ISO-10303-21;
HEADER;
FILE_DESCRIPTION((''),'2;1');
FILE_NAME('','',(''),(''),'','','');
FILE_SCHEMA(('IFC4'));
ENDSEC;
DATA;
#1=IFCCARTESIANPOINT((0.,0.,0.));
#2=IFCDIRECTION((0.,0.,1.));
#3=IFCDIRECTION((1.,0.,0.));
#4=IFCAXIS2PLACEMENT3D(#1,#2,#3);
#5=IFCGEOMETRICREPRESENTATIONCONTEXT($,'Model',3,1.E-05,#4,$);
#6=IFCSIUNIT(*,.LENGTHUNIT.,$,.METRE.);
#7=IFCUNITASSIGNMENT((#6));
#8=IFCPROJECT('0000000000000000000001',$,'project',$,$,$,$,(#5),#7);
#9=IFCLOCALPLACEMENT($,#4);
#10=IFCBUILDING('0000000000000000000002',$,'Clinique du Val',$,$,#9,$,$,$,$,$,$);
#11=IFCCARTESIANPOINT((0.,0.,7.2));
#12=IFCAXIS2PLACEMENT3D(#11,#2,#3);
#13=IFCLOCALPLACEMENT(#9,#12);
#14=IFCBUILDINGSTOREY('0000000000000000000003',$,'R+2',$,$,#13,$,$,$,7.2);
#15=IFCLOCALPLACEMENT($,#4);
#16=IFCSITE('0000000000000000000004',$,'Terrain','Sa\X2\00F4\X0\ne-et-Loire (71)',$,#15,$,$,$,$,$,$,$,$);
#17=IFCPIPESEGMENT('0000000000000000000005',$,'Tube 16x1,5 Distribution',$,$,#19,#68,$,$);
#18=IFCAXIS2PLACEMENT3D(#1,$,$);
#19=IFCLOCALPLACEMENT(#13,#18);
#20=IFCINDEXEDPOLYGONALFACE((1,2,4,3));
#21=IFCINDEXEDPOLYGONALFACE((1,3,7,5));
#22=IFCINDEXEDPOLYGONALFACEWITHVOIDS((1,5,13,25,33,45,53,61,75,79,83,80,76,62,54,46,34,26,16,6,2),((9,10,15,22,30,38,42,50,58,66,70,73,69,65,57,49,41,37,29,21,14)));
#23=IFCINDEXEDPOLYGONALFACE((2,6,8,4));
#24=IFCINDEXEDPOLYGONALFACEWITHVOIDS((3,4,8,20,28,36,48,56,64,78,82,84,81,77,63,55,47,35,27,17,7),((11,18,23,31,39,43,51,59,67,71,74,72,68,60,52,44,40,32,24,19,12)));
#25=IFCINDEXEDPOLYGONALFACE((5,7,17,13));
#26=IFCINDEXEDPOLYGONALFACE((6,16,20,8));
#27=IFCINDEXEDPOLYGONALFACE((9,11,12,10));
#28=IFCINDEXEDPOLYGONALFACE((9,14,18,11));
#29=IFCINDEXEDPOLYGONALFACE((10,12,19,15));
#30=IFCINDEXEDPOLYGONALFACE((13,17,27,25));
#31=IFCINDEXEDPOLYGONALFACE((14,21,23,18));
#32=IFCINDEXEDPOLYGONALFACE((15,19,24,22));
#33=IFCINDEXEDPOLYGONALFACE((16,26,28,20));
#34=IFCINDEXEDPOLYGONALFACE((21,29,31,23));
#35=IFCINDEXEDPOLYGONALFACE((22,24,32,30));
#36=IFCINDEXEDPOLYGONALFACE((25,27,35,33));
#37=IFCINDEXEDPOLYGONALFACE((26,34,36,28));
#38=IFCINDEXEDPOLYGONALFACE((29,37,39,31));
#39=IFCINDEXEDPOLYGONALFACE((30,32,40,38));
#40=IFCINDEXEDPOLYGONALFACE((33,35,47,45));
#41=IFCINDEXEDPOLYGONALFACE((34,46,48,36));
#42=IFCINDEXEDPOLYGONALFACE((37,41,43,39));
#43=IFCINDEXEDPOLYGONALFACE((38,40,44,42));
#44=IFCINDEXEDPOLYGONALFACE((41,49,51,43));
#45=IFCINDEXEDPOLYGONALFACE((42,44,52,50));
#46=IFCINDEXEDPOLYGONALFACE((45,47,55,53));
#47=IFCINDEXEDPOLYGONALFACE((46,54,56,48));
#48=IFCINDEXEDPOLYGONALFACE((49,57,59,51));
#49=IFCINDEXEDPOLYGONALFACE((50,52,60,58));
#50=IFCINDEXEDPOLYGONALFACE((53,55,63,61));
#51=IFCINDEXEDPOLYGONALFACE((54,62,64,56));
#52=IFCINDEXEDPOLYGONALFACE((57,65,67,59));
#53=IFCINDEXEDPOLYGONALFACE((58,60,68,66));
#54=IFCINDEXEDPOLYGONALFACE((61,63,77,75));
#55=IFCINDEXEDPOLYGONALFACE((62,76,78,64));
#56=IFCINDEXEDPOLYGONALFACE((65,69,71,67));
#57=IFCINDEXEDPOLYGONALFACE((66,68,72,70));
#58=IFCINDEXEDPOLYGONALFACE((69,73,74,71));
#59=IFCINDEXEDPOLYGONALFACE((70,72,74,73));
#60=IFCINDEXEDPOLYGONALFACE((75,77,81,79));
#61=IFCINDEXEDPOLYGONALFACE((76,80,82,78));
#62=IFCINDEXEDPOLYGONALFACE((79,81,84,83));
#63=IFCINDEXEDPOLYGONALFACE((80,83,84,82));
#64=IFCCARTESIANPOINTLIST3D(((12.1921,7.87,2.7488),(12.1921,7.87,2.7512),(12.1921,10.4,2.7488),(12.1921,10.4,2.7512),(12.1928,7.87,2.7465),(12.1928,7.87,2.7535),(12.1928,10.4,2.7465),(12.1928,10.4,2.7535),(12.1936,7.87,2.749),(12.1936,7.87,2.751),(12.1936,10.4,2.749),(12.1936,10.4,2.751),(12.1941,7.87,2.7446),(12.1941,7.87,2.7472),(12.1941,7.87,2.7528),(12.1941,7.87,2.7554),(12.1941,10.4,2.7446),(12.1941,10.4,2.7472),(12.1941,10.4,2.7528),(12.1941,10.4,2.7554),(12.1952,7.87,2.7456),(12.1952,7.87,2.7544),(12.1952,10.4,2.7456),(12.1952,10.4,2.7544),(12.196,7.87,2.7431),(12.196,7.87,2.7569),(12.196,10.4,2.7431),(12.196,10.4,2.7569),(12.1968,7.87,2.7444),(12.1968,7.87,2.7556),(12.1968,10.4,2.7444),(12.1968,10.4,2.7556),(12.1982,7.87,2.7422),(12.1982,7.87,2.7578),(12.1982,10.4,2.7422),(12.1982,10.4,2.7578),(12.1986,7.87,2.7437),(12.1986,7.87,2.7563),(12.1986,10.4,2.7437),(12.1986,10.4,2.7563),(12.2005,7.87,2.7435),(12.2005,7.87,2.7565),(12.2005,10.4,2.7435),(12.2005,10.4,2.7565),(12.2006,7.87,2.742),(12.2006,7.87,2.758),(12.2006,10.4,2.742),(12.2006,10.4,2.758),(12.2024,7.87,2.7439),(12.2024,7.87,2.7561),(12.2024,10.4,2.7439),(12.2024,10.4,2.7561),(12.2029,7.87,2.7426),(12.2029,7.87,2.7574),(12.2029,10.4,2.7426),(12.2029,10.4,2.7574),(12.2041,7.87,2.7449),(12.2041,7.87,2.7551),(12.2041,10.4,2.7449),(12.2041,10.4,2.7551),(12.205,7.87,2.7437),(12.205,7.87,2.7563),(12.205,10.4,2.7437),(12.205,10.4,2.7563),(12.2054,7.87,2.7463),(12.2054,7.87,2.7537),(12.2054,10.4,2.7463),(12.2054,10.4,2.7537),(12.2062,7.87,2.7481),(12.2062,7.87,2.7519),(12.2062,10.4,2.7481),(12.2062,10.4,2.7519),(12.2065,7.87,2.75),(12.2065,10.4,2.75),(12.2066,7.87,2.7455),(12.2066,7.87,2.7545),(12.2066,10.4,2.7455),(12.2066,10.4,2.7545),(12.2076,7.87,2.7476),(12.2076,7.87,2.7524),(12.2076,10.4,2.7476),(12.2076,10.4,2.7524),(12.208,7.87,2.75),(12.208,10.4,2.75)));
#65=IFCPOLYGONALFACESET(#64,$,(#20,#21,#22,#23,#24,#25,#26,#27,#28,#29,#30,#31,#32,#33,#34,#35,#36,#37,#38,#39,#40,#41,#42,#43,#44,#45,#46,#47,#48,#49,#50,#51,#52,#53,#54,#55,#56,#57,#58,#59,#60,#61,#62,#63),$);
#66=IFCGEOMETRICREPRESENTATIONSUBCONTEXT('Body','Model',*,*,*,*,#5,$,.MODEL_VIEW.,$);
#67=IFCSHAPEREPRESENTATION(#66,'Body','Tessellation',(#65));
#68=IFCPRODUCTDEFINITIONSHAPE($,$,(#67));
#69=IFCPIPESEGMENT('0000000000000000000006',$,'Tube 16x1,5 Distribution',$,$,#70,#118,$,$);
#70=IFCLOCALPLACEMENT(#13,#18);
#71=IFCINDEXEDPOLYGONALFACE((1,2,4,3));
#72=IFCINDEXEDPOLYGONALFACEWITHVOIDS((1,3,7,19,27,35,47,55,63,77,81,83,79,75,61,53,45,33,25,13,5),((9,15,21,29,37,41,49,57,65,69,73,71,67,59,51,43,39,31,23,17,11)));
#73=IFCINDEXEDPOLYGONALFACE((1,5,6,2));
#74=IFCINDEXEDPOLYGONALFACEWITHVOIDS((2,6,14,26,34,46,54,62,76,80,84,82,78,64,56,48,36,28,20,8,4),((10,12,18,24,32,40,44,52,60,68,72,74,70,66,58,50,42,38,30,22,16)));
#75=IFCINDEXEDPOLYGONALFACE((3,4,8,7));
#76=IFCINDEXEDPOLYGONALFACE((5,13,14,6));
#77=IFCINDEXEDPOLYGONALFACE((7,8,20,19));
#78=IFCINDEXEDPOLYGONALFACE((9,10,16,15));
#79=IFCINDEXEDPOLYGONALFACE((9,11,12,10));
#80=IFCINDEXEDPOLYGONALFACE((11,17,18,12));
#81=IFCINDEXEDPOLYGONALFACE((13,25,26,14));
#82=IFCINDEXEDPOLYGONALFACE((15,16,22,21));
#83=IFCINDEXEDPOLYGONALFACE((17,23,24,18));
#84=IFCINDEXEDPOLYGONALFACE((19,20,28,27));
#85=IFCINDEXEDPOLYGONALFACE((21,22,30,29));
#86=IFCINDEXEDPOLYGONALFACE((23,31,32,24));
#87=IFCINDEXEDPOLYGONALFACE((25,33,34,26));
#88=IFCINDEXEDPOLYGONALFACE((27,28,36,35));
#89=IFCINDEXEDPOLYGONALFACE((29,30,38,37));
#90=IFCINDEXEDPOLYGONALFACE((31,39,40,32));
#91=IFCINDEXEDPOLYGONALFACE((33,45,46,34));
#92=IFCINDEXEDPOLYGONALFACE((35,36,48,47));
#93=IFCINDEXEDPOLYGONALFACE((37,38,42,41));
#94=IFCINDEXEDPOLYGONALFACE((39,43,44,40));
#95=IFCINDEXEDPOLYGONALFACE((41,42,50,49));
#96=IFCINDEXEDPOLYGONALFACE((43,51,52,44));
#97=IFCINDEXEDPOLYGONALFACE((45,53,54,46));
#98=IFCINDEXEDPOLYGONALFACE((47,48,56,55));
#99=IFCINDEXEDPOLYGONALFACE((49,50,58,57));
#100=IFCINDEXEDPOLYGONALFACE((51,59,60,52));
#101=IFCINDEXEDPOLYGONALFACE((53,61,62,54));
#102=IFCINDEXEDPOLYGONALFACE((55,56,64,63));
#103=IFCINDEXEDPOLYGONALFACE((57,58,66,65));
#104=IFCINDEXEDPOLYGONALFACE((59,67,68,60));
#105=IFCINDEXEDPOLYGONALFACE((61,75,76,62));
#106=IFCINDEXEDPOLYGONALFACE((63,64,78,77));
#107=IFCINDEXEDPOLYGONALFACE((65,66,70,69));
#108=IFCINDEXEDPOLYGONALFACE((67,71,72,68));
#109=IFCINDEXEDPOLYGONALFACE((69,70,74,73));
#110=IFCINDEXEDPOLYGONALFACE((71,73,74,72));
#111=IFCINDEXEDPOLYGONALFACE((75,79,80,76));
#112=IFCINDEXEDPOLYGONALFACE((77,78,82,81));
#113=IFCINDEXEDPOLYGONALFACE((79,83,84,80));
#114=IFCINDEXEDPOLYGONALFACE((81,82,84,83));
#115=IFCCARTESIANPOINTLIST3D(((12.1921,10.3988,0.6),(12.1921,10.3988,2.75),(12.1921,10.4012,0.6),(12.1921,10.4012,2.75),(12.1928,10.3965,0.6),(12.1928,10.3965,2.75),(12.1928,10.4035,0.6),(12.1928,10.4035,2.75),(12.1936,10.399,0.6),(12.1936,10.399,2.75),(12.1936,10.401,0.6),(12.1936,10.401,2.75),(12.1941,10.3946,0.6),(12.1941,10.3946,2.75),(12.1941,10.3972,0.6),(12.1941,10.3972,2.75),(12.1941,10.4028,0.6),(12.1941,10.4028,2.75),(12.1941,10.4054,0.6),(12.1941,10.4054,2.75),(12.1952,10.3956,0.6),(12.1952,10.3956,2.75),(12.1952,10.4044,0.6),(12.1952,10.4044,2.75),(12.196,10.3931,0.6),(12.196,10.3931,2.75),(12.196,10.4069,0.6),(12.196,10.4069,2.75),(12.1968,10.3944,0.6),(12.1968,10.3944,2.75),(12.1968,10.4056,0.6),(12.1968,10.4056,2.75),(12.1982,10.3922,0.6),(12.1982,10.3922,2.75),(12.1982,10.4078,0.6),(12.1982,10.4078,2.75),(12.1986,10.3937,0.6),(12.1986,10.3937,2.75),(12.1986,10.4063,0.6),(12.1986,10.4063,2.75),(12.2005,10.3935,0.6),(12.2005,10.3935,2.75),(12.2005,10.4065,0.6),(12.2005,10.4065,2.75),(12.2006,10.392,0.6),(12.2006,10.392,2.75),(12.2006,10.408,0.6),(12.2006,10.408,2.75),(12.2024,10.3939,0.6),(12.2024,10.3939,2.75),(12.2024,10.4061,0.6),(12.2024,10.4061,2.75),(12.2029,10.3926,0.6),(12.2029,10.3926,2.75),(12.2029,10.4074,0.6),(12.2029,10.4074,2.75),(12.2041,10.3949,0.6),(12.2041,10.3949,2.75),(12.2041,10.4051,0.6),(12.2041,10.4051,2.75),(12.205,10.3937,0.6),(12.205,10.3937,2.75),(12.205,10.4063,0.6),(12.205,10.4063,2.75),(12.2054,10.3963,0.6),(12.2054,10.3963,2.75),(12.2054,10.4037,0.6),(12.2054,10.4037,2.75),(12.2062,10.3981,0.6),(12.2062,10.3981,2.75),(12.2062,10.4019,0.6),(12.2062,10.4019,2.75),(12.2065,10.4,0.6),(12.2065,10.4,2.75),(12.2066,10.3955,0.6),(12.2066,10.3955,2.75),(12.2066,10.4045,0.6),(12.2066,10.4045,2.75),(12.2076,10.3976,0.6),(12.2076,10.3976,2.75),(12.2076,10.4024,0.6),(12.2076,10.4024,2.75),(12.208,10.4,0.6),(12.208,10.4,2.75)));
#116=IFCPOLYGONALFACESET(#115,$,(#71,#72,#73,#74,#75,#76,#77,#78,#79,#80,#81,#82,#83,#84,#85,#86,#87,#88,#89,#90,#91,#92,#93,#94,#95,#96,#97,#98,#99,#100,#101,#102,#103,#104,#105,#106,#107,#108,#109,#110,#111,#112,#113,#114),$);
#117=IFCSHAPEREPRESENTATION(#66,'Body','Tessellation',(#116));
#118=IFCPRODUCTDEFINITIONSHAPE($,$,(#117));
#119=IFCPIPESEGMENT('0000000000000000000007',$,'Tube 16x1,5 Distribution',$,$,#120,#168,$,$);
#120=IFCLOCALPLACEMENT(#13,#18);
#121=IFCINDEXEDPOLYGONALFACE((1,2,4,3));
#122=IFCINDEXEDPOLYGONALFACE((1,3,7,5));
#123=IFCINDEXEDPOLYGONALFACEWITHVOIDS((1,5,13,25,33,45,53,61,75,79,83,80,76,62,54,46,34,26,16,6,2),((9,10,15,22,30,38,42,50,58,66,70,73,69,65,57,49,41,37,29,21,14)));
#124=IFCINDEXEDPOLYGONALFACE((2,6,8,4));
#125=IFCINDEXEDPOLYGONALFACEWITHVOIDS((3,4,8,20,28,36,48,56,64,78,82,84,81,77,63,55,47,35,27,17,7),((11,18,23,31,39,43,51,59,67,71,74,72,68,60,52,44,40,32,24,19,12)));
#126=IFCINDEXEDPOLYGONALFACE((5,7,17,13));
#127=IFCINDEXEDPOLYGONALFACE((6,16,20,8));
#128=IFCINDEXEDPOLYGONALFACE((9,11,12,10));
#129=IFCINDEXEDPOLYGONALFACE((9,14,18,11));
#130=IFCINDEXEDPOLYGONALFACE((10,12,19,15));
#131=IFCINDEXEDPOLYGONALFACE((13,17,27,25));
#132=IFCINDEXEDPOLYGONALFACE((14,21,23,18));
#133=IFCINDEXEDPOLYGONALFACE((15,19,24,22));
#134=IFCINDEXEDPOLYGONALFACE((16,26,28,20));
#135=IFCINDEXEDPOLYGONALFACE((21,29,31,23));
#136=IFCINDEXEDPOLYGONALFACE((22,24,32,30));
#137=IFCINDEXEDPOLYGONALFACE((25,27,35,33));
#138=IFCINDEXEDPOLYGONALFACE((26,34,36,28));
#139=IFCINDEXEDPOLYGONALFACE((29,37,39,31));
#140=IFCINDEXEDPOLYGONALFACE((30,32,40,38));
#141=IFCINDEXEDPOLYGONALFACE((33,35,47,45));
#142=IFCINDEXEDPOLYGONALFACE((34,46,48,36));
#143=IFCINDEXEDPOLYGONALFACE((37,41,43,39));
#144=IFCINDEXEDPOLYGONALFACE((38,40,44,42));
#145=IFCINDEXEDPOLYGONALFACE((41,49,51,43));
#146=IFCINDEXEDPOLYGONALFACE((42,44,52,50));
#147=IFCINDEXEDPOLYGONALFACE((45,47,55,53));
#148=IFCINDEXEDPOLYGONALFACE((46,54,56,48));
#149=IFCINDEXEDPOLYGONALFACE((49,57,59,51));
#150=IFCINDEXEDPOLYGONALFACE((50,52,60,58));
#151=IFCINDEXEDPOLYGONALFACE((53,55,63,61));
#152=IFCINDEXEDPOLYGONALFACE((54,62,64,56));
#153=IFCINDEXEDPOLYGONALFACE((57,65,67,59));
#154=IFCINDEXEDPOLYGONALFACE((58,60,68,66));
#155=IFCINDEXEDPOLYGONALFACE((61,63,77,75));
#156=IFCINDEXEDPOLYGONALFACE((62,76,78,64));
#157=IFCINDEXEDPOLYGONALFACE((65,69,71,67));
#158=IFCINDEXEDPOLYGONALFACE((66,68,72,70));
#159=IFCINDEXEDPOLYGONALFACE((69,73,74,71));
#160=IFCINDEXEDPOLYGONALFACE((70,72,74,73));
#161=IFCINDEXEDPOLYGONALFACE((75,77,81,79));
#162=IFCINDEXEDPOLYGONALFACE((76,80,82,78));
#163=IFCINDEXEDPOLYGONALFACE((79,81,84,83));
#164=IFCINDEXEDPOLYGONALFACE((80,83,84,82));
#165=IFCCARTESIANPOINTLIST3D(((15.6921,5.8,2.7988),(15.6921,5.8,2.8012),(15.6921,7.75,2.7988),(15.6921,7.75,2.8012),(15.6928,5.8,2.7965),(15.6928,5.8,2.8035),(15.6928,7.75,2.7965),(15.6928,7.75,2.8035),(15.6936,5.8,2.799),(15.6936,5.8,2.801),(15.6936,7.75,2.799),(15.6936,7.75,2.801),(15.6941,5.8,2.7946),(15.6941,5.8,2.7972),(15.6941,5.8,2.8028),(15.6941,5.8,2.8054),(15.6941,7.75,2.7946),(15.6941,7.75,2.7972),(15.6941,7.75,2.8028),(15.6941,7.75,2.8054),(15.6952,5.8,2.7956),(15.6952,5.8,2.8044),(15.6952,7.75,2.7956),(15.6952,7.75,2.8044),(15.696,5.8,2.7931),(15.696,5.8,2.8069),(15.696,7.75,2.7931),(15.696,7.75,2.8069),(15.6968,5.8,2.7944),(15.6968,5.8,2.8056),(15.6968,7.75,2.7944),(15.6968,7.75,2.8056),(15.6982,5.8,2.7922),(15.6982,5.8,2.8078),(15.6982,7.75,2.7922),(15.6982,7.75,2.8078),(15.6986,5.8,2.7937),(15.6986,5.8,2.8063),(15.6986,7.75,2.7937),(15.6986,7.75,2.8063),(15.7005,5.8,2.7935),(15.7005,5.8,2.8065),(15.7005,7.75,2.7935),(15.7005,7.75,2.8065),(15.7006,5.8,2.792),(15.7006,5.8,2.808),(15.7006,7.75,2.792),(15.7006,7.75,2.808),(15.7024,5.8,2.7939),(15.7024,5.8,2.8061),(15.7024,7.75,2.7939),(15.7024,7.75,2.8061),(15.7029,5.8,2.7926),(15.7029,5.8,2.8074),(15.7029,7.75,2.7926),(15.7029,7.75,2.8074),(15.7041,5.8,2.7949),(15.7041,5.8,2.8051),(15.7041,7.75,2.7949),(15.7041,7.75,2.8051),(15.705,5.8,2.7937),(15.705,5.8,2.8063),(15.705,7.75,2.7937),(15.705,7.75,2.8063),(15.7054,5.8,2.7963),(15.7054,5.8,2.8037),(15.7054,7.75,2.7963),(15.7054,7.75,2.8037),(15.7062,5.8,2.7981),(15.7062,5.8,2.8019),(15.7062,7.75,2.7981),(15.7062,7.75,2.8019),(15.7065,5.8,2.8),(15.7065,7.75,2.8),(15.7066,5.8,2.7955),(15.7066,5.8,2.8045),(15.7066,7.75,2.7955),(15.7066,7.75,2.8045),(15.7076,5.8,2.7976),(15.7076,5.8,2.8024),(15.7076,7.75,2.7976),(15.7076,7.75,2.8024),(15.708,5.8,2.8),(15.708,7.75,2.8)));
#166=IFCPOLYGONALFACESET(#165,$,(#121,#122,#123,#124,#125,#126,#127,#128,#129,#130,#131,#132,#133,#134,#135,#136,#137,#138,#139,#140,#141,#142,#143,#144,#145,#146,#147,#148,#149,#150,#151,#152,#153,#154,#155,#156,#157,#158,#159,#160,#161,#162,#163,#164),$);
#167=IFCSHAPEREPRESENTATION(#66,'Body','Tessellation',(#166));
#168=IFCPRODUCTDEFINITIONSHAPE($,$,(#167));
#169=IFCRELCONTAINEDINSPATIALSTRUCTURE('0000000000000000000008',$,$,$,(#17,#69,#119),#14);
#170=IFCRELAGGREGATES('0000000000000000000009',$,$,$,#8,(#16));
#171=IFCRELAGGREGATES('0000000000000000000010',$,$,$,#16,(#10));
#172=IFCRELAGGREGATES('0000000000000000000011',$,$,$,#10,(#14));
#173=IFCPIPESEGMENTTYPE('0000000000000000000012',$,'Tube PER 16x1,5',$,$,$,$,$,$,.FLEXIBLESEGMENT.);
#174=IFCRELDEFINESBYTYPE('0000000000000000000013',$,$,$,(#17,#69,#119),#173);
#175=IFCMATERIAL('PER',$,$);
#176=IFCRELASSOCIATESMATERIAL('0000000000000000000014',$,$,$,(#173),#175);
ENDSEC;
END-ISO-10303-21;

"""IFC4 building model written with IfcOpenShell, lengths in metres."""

from ifc_helpers import new_model, si_unit, frame, origin_with_axes, place, context, subcontext, project, spatial, hollow_circle, extrude, material, type_object, element, save


model = new_model("IFC4")

# Units and contexts
model_context = context("Model", 3, precision=1e-05, world=origin_with_axes())
body_context = subcontext(model_context, "Body", "Model", "MODEL_VIEW")
ifc_project = project(units=[si_unit("LENGTHUNIT", "METRE")], contexts=[model_context])

# Site, building, storey
site_placement = place(None, origin_with_axes())
site = spatial("IfcSite", under=ifc_project, at=site_placement, Name="Terrain", Description="Saône-et-Loire (71)")
building_placement = place(None, origin_with_axes())
building = spatial("IfcBuilding", under=site, at=building_placement, Name="Clinique du Val")
storey_placement = place(building_placement, frame((0.0, 0.0, 7.2), z_axis=(0.0, 0.0, 1.0), x_axis=(1.0, 0.0, 0.0)))
storey = spatial("IfcBuildingStorey", under=building, at=storey_placement, Name="R+2", Elevation=7.2)

# Pipe segments
ifc_material_1 = material(Name="PER")
pipe_segment_type_1 = type_object("IfcPipeSegmentType", Name="Tube PER 16x1,5", PredefinedType="FLEXIBLESEGMENT", material=ifc_material_1)
pipe_segment_1_placement = place(storey_placement, frame((12.2, 7.87, 2.75), z_axis=(0.0, 1.0, 0.0), x_axis=(1.0, 0.0, 0.0)))
element("IfcPipeSegment", 1, at=pipe_segment_1_placement, inside=storey, type_object=pipe_segment_type_1, Name="Tube 16x1,5 Distribution", context=body_context, shape_type="SweptSolid", body=[
    extrude(hollow_circle(Radius=0.008, WallThickness=0.0015), origin_with_axes(), (0.0, 0.0, 1.0), 2.53),
])
pipe_segment_2_placement = place(storey_placement, frame((12.2, 10.4, 2.75), z_axis=(0.0, 0.0, -1.0), x_axis=(1.0, 0.0, 0.0)))
element("IfcPipeSegment", 2, at=pipe_segment_2_placement, inside=storey, type_object=pipe_segment_type_1, Name="Tube 16x1,5 Distribution", context=body_context, shape_type="SweptSolid", body=[
    extrude(hollow_circle(Radius=0.008, WallThickness=0.0015), origin_with_axes(), (0.0, 0.0, 1.0), 2.15),
])
pipe_segment_3_placement = place(storey_placement, frame((15.7, 7.75, 2.8), z_axis=(0.0, -1.0, 0.0), x_axis=(1.0, 0.0, 0.0)))
element("IfcPipeSegment", 3, at=pipe_segment_3_placement, inside=storey, type_object=pipe_segment_type_1, Name="Tube 16x1,5 Distribution", context=body_context, shape_type="SweptSolid", body=[
    extrude(hollow_circle(Radius=0.008, WallThickness=0.0015), origin_with_axes(), (0.0, 0.0, 1.0), 1.95),
])

save(model, "model.ifc")
